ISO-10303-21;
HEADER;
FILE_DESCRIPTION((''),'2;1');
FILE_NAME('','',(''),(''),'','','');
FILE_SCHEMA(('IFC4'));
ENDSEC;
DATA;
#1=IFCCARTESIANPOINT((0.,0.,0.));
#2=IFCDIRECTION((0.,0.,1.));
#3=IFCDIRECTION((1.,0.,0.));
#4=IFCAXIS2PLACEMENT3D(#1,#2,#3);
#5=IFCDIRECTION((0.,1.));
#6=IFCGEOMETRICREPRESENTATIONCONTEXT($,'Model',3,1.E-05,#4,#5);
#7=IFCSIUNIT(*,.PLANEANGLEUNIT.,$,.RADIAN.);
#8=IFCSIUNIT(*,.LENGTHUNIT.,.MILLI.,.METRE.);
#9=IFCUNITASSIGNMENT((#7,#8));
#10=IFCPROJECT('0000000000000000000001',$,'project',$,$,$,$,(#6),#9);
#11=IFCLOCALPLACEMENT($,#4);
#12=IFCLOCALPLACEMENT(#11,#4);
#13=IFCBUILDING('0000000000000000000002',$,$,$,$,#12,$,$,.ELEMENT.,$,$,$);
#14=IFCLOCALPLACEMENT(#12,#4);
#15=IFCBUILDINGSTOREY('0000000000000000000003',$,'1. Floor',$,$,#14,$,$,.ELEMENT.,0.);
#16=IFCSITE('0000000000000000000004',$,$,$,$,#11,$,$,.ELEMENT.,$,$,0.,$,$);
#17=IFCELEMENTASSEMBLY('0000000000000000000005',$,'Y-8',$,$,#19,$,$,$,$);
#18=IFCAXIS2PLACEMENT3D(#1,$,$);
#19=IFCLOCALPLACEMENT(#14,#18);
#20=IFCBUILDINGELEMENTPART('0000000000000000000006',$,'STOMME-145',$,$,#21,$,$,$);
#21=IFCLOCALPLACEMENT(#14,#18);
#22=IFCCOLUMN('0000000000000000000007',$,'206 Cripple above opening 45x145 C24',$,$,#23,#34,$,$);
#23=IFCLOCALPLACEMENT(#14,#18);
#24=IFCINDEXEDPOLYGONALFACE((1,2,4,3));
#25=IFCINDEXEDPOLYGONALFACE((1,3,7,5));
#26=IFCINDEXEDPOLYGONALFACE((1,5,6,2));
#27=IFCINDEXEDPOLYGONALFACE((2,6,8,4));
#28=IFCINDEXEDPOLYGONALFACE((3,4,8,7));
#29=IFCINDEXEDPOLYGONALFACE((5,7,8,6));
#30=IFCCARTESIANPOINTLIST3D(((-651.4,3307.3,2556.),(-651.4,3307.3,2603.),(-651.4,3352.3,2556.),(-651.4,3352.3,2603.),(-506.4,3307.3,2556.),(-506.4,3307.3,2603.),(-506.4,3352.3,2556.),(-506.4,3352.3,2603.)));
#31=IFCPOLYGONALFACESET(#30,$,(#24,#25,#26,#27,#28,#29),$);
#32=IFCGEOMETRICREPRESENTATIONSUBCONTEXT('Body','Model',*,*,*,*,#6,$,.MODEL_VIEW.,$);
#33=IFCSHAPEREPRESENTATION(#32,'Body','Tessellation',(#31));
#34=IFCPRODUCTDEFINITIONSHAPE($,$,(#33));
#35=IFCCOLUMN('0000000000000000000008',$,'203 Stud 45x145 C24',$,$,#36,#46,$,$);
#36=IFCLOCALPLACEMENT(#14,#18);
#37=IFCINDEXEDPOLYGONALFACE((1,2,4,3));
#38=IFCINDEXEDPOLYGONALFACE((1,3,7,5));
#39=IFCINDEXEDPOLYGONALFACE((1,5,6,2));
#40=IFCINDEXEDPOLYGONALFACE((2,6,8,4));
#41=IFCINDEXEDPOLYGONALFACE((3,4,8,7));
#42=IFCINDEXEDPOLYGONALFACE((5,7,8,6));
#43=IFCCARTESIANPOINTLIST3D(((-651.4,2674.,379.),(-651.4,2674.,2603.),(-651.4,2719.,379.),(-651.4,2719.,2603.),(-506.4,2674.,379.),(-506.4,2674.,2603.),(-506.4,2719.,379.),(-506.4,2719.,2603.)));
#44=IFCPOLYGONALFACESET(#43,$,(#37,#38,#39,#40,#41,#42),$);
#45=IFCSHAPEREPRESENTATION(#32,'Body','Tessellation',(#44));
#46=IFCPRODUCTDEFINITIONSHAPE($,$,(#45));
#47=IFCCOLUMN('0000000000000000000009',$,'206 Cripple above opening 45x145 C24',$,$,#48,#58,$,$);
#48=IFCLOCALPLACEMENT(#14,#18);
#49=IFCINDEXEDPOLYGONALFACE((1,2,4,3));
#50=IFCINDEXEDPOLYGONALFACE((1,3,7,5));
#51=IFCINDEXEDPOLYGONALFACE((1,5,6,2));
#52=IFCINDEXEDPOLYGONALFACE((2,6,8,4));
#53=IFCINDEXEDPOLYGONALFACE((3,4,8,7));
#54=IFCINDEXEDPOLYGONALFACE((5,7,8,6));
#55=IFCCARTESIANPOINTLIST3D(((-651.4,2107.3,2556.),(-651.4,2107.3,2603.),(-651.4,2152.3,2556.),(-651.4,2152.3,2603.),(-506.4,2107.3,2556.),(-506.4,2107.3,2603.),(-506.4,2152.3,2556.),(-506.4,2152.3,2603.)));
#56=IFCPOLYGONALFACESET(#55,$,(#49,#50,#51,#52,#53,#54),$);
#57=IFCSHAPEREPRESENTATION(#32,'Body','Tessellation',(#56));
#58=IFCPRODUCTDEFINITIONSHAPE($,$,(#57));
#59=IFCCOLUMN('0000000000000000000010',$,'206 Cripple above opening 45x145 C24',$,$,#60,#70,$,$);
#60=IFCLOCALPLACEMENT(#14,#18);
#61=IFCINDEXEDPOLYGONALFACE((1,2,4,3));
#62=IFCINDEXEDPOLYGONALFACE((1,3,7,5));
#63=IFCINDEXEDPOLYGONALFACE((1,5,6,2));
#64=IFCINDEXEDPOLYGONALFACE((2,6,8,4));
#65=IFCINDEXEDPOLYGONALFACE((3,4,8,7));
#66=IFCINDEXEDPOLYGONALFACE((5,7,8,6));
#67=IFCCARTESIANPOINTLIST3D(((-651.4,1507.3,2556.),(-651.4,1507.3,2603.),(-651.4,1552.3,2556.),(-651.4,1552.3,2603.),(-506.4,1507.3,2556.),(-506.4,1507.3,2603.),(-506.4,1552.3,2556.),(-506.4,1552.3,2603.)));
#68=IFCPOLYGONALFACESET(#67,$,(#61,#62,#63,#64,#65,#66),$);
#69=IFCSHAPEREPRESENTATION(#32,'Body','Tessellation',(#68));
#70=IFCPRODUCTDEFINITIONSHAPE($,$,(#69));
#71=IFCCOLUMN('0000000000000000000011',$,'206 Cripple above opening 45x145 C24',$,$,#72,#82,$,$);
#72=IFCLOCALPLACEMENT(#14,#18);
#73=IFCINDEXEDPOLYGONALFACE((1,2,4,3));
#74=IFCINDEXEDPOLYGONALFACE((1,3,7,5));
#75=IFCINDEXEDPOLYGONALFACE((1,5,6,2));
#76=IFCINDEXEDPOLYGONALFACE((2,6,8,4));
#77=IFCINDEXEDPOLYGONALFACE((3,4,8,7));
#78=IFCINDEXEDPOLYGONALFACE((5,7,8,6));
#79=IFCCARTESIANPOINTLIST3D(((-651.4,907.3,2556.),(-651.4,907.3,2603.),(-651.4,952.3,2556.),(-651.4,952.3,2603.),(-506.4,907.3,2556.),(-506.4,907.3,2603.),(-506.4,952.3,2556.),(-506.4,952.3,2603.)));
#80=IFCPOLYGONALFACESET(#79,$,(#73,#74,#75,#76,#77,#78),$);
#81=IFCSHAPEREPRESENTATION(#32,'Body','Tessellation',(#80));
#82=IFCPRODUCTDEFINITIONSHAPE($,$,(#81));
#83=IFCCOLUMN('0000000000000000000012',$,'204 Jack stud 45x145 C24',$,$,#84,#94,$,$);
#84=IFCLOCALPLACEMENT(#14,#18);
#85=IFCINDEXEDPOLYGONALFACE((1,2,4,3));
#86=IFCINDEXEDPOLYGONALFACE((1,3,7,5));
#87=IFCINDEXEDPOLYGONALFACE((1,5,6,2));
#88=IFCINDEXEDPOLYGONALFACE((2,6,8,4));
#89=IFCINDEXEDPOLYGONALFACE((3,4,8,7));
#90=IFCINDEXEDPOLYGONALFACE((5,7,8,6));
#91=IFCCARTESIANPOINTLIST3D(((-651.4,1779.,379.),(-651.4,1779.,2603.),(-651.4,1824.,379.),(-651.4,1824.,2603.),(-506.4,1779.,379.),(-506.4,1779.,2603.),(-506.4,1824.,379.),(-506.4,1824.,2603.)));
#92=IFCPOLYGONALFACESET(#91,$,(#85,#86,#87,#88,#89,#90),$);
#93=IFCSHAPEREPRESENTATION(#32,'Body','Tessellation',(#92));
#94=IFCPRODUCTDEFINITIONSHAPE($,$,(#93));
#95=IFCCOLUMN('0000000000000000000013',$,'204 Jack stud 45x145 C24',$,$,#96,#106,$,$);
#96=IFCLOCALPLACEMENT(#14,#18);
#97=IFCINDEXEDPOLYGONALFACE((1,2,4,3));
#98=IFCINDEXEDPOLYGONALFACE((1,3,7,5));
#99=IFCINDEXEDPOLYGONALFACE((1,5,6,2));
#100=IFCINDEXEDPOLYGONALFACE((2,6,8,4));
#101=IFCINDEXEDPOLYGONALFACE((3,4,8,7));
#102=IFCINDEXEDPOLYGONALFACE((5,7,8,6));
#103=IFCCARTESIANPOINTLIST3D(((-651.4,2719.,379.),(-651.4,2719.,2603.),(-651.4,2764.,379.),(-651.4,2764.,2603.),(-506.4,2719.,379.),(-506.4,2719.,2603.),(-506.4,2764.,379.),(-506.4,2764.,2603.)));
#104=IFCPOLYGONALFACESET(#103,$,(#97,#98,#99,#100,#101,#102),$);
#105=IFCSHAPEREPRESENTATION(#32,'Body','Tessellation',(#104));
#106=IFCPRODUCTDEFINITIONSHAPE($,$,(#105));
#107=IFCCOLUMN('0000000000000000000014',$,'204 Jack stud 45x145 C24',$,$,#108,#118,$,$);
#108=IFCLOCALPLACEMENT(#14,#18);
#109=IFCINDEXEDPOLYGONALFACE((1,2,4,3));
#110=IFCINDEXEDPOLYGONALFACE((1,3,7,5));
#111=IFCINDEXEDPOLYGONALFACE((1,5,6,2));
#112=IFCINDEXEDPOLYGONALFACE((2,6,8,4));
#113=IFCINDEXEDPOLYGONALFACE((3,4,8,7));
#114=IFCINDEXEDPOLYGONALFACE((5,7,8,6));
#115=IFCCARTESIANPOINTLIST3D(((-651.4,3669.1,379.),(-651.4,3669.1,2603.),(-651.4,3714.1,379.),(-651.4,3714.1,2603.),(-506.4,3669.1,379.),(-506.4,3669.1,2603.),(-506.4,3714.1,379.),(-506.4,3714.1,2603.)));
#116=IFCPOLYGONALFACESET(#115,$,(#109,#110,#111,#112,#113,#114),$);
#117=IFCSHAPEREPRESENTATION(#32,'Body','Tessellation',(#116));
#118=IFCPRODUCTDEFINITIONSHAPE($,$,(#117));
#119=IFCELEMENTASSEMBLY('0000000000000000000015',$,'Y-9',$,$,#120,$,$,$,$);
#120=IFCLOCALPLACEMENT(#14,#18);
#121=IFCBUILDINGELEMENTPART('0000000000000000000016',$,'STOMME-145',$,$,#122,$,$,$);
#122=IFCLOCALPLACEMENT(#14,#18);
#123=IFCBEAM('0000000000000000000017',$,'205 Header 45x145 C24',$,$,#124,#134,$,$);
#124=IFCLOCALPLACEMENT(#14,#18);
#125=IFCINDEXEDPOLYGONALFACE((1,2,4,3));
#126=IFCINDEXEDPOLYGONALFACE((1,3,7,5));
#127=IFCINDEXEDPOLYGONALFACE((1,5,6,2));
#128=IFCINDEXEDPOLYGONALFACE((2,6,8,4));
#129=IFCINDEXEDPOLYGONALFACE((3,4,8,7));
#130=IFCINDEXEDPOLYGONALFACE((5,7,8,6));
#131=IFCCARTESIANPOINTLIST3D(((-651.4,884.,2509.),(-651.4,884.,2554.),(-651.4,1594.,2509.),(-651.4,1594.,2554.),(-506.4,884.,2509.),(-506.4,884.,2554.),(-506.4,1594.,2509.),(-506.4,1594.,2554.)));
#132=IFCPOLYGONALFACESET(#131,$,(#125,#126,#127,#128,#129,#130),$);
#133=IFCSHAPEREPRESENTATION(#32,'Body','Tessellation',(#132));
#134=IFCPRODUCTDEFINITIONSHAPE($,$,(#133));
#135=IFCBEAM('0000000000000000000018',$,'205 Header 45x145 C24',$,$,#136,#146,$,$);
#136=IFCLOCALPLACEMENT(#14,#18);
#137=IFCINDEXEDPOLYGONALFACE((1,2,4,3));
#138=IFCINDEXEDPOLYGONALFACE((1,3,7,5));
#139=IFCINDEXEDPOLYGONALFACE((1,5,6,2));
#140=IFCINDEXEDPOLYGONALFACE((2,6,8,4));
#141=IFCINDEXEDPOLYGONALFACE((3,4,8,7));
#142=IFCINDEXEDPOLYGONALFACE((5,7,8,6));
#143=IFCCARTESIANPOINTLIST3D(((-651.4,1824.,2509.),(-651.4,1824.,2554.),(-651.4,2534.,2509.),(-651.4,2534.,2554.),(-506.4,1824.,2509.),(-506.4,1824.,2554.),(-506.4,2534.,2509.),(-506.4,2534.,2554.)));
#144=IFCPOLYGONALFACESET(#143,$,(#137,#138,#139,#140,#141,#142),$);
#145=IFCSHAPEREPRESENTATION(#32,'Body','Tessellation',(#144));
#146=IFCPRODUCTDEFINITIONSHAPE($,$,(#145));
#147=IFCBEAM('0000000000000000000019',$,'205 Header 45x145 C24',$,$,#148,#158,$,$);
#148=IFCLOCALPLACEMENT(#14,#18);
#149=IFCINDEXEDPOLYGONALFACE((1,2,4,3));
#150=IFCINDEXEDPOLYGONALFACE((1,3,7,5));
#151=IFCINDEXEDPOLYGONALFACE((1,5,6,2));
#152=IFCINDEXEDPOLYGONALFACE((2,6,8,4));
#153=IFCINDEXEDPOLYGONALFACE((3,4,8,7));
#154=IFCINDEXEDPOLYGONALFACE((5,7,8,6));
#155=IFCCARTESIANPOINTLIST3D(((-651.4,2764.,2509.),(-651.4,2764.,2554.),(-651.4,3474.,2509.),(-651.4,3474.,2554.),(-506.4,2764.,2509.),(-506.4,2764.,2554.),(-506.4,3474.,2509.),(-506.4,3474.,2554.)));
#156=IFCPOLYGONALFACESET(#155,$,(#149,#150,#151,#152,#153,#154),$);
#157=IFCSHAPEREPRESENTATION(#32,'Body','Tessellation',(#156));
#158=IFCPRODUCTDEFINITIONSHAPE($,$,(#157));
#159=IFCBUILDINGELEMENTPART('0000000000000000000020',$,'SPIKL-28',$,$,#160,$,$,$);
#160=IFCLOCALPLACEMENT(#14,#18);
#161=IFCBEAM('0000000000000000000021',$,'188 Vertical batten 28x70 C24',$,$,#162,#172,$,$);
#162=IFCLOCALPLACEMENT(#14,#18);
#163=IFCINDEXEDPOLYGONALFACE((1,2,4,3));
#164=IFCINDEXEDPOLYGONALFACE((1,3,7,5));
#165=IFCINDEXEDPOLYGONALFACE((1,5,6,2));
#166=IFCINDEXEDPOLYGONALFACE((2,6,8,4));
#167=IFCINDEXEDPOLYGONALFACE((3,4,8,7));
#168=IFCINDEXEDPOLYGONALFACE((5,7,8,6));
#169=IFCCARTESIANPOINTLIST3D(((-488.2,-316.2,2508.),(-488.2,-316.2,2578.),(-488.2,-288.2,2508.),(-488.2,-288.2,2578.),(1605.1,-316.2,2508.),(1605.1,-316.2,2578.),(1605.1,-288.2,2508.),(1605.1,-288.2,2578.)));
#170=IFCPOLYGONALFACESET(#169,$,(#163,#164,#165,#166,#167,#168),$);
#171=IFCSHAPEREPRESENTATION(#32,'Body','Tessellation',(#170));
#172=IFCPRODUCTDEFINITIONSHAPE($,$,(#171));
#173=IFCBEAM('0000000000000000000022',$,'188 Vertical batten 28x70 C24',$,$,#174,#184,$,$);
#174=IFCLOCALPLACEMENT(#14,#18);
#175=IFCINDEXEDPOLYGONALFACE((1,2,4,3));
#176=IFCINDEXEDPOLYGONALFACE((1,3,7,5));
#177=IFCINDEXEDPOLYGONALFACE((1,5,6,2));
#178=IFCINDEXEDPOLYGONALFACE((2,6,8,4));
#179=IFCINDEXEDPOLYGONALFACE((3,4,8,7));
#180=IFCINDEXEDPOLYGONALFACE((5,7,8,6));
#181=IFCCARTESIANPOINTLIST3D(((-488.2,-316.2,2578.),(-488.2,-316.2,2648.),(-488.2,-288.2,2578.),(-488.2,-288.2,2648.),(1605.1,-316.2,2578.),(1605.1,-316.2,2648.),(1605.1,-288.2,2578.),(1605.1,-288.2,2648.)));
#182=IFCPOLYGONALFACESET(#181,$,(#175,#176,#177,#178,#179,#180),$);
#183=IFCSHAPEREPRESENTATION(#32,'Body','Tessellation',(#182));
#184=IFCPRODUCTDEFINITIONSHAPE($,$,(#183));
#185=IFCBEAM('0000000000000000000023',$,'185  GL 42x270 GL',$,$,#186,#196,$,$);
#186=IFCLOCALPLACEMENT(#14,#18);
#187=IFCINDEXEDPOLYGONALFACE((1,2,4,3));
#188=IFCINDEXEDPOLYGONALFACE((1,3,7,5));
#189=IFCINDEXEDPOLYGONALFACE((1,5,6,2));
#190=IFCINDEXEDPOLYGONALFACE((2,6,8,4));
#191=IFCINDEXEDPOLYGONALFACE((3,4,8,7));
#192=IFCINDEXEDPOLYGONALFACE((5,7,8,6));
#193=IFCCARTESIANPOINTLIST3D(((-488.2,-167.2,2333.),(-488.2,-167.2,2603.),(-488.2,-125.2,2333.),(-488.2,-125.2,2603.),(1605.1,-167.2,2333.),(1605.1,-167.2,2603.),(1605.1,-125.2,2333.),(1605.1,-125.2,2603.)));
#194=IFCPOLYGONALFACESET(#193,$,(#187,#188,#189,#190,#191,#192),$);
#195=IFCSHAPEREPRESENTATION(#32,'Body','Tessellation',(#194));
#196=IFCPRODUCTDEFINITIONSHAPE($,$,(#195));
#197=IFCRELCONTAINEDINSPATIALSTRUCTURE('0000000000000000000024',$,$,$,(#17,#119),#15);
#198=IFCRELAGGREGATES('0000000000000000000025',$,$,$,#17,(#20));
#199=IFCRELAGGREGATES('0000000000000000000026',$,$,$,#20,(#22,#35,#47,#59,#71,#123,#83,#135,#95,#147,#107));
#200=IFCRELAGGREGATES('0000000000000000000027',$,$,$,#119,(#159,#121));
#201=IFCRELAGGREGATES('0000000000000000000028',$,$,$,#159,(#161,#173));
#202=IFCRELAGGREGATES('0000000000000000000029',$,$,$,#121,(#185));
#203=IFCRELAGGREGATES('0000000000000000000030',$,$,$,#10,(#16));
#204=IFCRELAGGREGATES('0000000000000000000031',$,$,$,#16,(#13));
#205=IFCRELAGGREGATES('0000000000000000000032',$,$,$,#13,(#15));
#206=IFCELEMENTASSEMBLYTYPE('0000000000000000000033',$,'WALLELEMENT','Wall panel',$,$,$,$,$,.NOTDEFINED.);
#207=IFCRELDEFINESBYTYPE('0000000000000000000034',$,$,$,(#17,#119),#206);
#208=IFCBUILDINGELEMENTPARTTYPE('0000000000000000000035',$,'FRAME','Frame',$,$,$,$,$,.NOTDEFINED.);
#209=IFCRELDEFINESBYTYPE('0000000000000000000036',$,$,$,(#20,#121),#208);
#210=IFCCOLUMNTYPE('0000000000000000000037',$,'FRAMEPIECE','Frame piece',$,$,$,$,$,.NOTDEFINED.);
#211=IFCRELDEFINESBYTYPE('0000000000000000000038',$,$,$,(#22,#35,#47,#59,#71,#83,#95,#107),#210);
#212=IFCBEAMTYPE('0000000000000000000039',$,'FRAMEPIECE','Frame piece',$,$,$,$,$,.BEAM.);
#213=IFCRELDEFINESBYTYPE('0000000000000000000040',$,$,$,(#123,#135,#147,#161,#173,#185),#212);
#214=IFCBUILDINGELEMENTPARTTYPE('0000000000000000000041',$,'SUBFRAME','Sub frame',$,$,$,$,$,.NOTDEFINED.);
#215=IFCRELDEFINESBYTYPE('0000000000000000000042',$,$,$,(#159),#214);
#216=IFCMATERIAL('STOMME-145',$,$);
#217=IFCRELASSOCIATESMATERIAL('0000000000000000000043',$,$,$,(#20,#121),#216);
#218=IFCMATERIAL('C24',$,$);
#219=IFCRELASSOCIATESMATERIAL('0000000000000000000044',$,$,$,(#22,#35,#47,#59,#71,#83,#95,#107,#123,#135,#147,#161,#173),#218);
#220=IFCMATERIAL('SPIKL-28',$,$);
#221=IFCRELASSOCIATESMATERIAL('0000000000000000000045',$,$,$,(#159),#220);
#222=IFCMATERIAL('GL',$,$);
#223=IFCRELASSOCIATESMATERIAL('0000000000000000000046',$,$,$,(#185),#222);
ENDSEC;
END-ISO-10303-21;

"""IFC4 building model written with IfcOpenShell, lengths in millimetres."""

from ifc_helpers import new_model, si_unit, direction, frame, origin_with_axes, origin_2d_with_axis, place, context, subcontext, project, spatial, rectangle, extrude, material, type_object, element, aggregate, save


model = new_model("IFC4")

# Units and contexts
model_context = context("Model", 3, precision=1e-05, world=origin_with_axes(), true_north=direction((0.0, 1.0)))
body_context = subcontext(model_context, "Body", "Model", "MODEL_VIEW")
ifc_project = project(units=[si_unit("PLANEANGLEUNIT", "RADIAN"), si_unit("LENGTHUNIT", "METRE", prefix="MILLI")], contexts=[model_context])

# Site, building, storey
site_placement = place(None, origin_with_axes())
site = spatial("IfcSite", under=ifc_project, at=site_placement, CompositionType="ELEMENT", RefElevation=0.0)
building_placement = place(site_placement, origin_with_axes())
building = spatial("IfcBuilding", under=site, at=building_placement, CompositionType="ELEMENT")
storey_placement = place(building_placement, origin_with_axes())
storey = spatial("IfcBuildingStorey", under=building, at=storey_placement, Name="1. Floor", CompositionType="ELEMENT", Elevation=0.0)

# Element assemblies, building element parts, columns
element_assembly_type_1 = type_object("IfcElementAssemblyType", Name="WALLELEMENT", Description="Wall panel", PredefinedType="NOTDEFINED")
assembly_1_placement = place(storey_placement, origin_with_axes())
assembly_1 = element("IfcElementAssembly", 1, at=assembly_1_placement, inside=storey, type_object=element_assembly_type_1, Name="Y-8")
ifc_material_1 = material(Name="STOMME-145")
building_element_part_type_1 = type_object("IfcBuildingElementPartType", Name="FRAME", Description="Frame", PredefinedType="NOTDEFINED")
building_element_part_1_placement = place(storey_placement, origin_with_axes())
building_element_part_1 = element("IfcBuildingElementPart", 2, at=building_element_part_1_placement, type_object=building_element_part_type_1, material=ifc_material_1, Name="STOMME-145")
aggregate(assembly_1, [building_element_part_1])
ifc_material_2 = material(Name="C24")
column_type = type_object("IfcColumnType", Name="FRAMEPIECE", Description="Frame piece", PredefinedType="NOTDEFINED")
column_1_placement = place(storey_placement, frame((-578.9, 3329.8, 2603.0), z_axis=(0.0, 0.0, -1.0), x_axis=(0.0, -1.0, 0.0)))
column_1 = element("IfcColumn", 3, at=column_1_placement, type_object=column_type, material=ifc_material_2, Name="206 Cripple above opening 45x145 C24", context=body_context, shape_type="SweptSolid", body=[
    extrude(rectangle(XDim=45.0, YDim=145.0, at=origin_2d_with_axis()), origin_with_axes(), (0.0, 0.0, 1.0), 47.0),
])
column_2_placement = place(storey_placement, frame((-578.9, 2696.5, 2603.0), z_axis=(0.0, 0.0, -1.0), x_axis=(0.0, -1.0, 0.0)))
column_2 = element("IfcColumn", 4, at=column_2_placement, type_object=column_type, material=ifc_material_2, Name="203 Stud 45x145 C24", context=body_context, shape_type="SweptSolid", body=[
    extrude(rectangle(XDim=45.0, YDim=145.0, at=origin_2d_with_axis()), origin_with_axes(), (0.0, 0.0, 1.0), 2224.0),
])
column_3_placement = place(storey_placement, frame((-578.9, 2129.8, 2603.0), z_axis=(0.0, 0.0, -1.0), x_axis=(0.0, -1.0, 0.0)))
column_3 = element("IfcColumn", 5, at=column_3_placement, type_object=column_type, material=ifc_material_2, Name="206 Cripple above opening 45x145 C24", context=body_context, shape_type="SweptSolid", body=[
    extrude(rectangle(XDim=45.0, YDim=145.0, at=origin_2d_with_axis()), origin_with_axes(), (0.0, 0.0, 1.0), 47.0),
])
column_4_placement = place(storey_placement, frame((-578.9, 1529.8, 2603.0), z_axis=(0.0, 0.0, -1.0), x_axis=(0.0, -1.0, 0.0)))
column_4 = element("IfcColumn", 6, at=column_4_placement, type_object=column_type, material=ifc_material_2, Name="206 Cripple above opening 45x145 C24", context=body_context, shape_type="SweptSolid", body=[
    extrude(rectangle(XDim=45.0, YDim=145.0, at=origin_2d_with_axis()), origin_with_axes(), (0.0, 0.0, 1.0), 47.0),
])
column_5_placement = place(storey_placement, frame((-578.9, 929.8, 2603.0), z_axis=(0.0, 0.0, -1.0), x_axis=(0.0, -1.0, 0.0)))
column_5 = element("IfcColumn", 7, at=column_5_placement, type_object=column_type, material=ifc_material_2, Name="206 Cripple above opening 45x145 C24", context=body_context, shape_type="SweptSolid", body=[
    extrude(rectangle(XDim=45.0, YDim=145.0, at=origin_2d_with_axis()), origin_with_axes(), (0.0, 0.0, 1.0), 47.0),
])
column_6_placement = place(storey_placement, frame((-578.9, 1801.5, 2603.0), z_axis=(0.0, 0.0, -1.0), x_axis=(0.0, -1.0, 0.0)))
column_6 = element("IfcColumn", 8, at=column_6_placement, type_object=column_type, material=ifc_material_2, Name="204 Jack stud 45x145 C24", context=body_context, shape_type="SweptSolid", body=[
    extrude(rectangle(XDim=45.0, YDim=145.0, at=origin_2d_with_axis()), origin_with_axes(), (0.0, 0.0, 1.0), 2224.0),
])
column_7_placement = place(storey_placement, frame((-578.9, 2741.5, 2603.0), z_axis=(0.0, 0.0, -1.0), x_axis=(0.0, -1.0, 0.0)))
column_7 = element("IfcColumn", 9, at=column_7_placement, type_object=column_type, material=ifc_material_2, Name="204 Jack stud 45x145 C24", context=body_context, shape_type="SweptSolid", body=[
    extrude(rectangle(XDim=45.0, YDim=145.0, at=origin_2d_with_axis()), origin_with_axes(), (0.0, 0.0, 1.0), 2224.0),
])
column_8_placement = place(storey_placement, frame((-578.9, 3691.6, 2603.0), z_axis=(0.0, 0.0, -1.0), x_axis=(0.0, -1.0, 0.0)))
column_8 = element("IfcColumn", 10, at=column_8_placement, type_object=column_type, material=ifc_material_2, Name="204 Jack stud 45x145 C24", context=body_context, shape_type="SweptSolid", body=[
    extrude(rectangle(XDim=45.0, YDim=145.0, at=origin_2d_with_axis()), origin_with_axes(), (0.0, 0.0, 1.0), 2224.0),
])
assembly_2_placement = place(storey_placement, origin_with_axes())
assembly_2 = element("IfcElementAssembly", 11, at=assembly_2_placement, inside=storey, type_object=element_assembly_type_1, Name="Y-9")
building_element_part_2_placement = place(storey_placement, origin_with_axes())
building_element_part_2 = element("IfcBuildingElementPart", 12, at=building_element_part_2_placement, type_object=building_element_part_type_1, material=ifc_material_1, Name="STOMME-145")

# Beams
beam_type = type_object("IfcBeamType", Name="FRAMEPIECE", Description="Frame piece", PredefinedType="BEAM")
beam_1_placement = place(storey_placement, frame((-578.9, 1594.0, 2531.5), z_axis=(0.0, -1.0, 0.0), x_axis=(0.0, 0.0, 1.0)))
beam_1 = element("IfcBeam", 13, at=beam_1_placement, type_object=beam_type, material=ifc_material_2, Name="205 Header 45x145 C24", context=body_context, shape_type="SweptSolid", body=[
    extrude(rectangle(XDim=45.0, YDim=145.0, at=origin_2d_with_axis()), origin_with_axes(), (0.0, 0.0, 1.0), 710.0),
])
beam_2_placement = place(storey_placement, frame((-578.9, 2534.0, 2531.5), z_axis=(0.0, -1.0, 0.0), x_axis=(0.0, 0.0, 1.0)))
beam_2 = element("IfcBeam", 14, at=beam_2_placement, type_object=beam_type, material=ifc_material_2, Name="205 Header 45x145 C24", context=body_context, shape_type="SweptSolid", body=[
    extrude(rectangle(XDim=45.0, YDim=145.0, at=origin_2d_with_axis()), origin_with_axes(), (0.0, 0.0, 1.0), 710.0),
])
beam_3_placement = place(storey_placement, frame((-578.9, 3474.0, 2531.5), z_axis=(0.0, -1.0, 0.0), x_axis=(0.0, 0.0, 1.0)))
beam_3 = element("IfcBeam", 15, at=beam_3_placement, type_object=beam_type, material=ifc_material_2, Name="205 Header 45x145 C24", context=body_context, shape_type="SweptSolid", body=[
    extrude(rectangle(XDim=45.0, YDim=145.0, at=origin_2d_with_axis()), origin_with_axes(), (0.0, 0.0, 1.0), 710.0),
])
aggregate(building_element_part_1, [column_1, column_2, column_3, column_4, column_5, beam_1, column_6, beam_2, column_7, beam_3, column_8])

# Building element part
ifc_material_3 = material(Name="SPIKL-28")
building_element_part_type_2 = type_object("IfcBuildingElementPartType", Name="SUBFRAME", Description="Sub frame", PredefinedType="NOTDEFINED")
building_element_part_3_placement = place(storey_placement, origin_with_axes())
building_element_part_3 = element("IfcBuildingElementPart", 16, at=building_element_part_3_placement, type_object=building_element_part_type_2, material=ifc_material_3, Name="SPIKL-28")
aggregate(assembly_2, [building_element_part_3, building_element_part_2])

# Beams
beam_4_placement = place(storey_placement, frame((-488.2, -302.2, 2543.0), z_axis=(1.0, 0.0, 0.0), x_axis=(0.0, -1.0, 0.0)))
beam_4 = element("IfcBeam", 17, at=beam_4_placement, type_object=beam_type, material=ifc_material_2, Name="188 Vertical batten 28x70 C24", context=body_context, shape_type="SweptSolid", body=[
    extrude(rectangle(XDim=28.0, YDim=70.0, at=origin_2d_with_axis()), origin_with_axes(), (0.0, 0.0, 1.0), 2093.3),
])
beam_5_placement = place(storey_placement, frame((-488.2, -302.2, 2613.0), z_axis=(1.0, 0.0, 0.0), x_axis=(0.0, -1.0, 0.0)))
beam_5 = element("IfcBeam", 18, at=beam_5_placement, type_object=beam_type, material=ifc_material_2, Name="188 Vertical batten 28x70 C24", context=body_context, shape_type="SweptSolid", body=[
    extrude(rectangle(XDim=28.0, YDim=70.0, at=origin_2d_with_axis()), origin_with_axes(), (0.0, 0.0, 1.0), 2093.4),
])
aggregate(building_element_part_3, [beam_4, beam_5])
ifc_material_4 = material(Name="GL")
beam_6_placement = place(storey_placement, frame((-488.2, -146.2, 2468.0), z_axis=(1.0, 0.0, 0.0), x_axis=(0.0, -1.0, 0.0)))
beam_6 = element("IfcBeam", 19, at=beam_6_placement, type_object=beam_type, material=ifc_material_4, Name="185  GL 42x270 GL", context=body_context, shape_type="SweptSolid", body=[
    extrude(rectangle(XDim=42.0, YDim=270.0, at=origin_2d_with_axis()), origin_with_axes(), (0.0, 0.0, 1.0), 2093.3),
])
aggregate(building_element_part_2, [beam_6])

save(model, "model.ifc")
